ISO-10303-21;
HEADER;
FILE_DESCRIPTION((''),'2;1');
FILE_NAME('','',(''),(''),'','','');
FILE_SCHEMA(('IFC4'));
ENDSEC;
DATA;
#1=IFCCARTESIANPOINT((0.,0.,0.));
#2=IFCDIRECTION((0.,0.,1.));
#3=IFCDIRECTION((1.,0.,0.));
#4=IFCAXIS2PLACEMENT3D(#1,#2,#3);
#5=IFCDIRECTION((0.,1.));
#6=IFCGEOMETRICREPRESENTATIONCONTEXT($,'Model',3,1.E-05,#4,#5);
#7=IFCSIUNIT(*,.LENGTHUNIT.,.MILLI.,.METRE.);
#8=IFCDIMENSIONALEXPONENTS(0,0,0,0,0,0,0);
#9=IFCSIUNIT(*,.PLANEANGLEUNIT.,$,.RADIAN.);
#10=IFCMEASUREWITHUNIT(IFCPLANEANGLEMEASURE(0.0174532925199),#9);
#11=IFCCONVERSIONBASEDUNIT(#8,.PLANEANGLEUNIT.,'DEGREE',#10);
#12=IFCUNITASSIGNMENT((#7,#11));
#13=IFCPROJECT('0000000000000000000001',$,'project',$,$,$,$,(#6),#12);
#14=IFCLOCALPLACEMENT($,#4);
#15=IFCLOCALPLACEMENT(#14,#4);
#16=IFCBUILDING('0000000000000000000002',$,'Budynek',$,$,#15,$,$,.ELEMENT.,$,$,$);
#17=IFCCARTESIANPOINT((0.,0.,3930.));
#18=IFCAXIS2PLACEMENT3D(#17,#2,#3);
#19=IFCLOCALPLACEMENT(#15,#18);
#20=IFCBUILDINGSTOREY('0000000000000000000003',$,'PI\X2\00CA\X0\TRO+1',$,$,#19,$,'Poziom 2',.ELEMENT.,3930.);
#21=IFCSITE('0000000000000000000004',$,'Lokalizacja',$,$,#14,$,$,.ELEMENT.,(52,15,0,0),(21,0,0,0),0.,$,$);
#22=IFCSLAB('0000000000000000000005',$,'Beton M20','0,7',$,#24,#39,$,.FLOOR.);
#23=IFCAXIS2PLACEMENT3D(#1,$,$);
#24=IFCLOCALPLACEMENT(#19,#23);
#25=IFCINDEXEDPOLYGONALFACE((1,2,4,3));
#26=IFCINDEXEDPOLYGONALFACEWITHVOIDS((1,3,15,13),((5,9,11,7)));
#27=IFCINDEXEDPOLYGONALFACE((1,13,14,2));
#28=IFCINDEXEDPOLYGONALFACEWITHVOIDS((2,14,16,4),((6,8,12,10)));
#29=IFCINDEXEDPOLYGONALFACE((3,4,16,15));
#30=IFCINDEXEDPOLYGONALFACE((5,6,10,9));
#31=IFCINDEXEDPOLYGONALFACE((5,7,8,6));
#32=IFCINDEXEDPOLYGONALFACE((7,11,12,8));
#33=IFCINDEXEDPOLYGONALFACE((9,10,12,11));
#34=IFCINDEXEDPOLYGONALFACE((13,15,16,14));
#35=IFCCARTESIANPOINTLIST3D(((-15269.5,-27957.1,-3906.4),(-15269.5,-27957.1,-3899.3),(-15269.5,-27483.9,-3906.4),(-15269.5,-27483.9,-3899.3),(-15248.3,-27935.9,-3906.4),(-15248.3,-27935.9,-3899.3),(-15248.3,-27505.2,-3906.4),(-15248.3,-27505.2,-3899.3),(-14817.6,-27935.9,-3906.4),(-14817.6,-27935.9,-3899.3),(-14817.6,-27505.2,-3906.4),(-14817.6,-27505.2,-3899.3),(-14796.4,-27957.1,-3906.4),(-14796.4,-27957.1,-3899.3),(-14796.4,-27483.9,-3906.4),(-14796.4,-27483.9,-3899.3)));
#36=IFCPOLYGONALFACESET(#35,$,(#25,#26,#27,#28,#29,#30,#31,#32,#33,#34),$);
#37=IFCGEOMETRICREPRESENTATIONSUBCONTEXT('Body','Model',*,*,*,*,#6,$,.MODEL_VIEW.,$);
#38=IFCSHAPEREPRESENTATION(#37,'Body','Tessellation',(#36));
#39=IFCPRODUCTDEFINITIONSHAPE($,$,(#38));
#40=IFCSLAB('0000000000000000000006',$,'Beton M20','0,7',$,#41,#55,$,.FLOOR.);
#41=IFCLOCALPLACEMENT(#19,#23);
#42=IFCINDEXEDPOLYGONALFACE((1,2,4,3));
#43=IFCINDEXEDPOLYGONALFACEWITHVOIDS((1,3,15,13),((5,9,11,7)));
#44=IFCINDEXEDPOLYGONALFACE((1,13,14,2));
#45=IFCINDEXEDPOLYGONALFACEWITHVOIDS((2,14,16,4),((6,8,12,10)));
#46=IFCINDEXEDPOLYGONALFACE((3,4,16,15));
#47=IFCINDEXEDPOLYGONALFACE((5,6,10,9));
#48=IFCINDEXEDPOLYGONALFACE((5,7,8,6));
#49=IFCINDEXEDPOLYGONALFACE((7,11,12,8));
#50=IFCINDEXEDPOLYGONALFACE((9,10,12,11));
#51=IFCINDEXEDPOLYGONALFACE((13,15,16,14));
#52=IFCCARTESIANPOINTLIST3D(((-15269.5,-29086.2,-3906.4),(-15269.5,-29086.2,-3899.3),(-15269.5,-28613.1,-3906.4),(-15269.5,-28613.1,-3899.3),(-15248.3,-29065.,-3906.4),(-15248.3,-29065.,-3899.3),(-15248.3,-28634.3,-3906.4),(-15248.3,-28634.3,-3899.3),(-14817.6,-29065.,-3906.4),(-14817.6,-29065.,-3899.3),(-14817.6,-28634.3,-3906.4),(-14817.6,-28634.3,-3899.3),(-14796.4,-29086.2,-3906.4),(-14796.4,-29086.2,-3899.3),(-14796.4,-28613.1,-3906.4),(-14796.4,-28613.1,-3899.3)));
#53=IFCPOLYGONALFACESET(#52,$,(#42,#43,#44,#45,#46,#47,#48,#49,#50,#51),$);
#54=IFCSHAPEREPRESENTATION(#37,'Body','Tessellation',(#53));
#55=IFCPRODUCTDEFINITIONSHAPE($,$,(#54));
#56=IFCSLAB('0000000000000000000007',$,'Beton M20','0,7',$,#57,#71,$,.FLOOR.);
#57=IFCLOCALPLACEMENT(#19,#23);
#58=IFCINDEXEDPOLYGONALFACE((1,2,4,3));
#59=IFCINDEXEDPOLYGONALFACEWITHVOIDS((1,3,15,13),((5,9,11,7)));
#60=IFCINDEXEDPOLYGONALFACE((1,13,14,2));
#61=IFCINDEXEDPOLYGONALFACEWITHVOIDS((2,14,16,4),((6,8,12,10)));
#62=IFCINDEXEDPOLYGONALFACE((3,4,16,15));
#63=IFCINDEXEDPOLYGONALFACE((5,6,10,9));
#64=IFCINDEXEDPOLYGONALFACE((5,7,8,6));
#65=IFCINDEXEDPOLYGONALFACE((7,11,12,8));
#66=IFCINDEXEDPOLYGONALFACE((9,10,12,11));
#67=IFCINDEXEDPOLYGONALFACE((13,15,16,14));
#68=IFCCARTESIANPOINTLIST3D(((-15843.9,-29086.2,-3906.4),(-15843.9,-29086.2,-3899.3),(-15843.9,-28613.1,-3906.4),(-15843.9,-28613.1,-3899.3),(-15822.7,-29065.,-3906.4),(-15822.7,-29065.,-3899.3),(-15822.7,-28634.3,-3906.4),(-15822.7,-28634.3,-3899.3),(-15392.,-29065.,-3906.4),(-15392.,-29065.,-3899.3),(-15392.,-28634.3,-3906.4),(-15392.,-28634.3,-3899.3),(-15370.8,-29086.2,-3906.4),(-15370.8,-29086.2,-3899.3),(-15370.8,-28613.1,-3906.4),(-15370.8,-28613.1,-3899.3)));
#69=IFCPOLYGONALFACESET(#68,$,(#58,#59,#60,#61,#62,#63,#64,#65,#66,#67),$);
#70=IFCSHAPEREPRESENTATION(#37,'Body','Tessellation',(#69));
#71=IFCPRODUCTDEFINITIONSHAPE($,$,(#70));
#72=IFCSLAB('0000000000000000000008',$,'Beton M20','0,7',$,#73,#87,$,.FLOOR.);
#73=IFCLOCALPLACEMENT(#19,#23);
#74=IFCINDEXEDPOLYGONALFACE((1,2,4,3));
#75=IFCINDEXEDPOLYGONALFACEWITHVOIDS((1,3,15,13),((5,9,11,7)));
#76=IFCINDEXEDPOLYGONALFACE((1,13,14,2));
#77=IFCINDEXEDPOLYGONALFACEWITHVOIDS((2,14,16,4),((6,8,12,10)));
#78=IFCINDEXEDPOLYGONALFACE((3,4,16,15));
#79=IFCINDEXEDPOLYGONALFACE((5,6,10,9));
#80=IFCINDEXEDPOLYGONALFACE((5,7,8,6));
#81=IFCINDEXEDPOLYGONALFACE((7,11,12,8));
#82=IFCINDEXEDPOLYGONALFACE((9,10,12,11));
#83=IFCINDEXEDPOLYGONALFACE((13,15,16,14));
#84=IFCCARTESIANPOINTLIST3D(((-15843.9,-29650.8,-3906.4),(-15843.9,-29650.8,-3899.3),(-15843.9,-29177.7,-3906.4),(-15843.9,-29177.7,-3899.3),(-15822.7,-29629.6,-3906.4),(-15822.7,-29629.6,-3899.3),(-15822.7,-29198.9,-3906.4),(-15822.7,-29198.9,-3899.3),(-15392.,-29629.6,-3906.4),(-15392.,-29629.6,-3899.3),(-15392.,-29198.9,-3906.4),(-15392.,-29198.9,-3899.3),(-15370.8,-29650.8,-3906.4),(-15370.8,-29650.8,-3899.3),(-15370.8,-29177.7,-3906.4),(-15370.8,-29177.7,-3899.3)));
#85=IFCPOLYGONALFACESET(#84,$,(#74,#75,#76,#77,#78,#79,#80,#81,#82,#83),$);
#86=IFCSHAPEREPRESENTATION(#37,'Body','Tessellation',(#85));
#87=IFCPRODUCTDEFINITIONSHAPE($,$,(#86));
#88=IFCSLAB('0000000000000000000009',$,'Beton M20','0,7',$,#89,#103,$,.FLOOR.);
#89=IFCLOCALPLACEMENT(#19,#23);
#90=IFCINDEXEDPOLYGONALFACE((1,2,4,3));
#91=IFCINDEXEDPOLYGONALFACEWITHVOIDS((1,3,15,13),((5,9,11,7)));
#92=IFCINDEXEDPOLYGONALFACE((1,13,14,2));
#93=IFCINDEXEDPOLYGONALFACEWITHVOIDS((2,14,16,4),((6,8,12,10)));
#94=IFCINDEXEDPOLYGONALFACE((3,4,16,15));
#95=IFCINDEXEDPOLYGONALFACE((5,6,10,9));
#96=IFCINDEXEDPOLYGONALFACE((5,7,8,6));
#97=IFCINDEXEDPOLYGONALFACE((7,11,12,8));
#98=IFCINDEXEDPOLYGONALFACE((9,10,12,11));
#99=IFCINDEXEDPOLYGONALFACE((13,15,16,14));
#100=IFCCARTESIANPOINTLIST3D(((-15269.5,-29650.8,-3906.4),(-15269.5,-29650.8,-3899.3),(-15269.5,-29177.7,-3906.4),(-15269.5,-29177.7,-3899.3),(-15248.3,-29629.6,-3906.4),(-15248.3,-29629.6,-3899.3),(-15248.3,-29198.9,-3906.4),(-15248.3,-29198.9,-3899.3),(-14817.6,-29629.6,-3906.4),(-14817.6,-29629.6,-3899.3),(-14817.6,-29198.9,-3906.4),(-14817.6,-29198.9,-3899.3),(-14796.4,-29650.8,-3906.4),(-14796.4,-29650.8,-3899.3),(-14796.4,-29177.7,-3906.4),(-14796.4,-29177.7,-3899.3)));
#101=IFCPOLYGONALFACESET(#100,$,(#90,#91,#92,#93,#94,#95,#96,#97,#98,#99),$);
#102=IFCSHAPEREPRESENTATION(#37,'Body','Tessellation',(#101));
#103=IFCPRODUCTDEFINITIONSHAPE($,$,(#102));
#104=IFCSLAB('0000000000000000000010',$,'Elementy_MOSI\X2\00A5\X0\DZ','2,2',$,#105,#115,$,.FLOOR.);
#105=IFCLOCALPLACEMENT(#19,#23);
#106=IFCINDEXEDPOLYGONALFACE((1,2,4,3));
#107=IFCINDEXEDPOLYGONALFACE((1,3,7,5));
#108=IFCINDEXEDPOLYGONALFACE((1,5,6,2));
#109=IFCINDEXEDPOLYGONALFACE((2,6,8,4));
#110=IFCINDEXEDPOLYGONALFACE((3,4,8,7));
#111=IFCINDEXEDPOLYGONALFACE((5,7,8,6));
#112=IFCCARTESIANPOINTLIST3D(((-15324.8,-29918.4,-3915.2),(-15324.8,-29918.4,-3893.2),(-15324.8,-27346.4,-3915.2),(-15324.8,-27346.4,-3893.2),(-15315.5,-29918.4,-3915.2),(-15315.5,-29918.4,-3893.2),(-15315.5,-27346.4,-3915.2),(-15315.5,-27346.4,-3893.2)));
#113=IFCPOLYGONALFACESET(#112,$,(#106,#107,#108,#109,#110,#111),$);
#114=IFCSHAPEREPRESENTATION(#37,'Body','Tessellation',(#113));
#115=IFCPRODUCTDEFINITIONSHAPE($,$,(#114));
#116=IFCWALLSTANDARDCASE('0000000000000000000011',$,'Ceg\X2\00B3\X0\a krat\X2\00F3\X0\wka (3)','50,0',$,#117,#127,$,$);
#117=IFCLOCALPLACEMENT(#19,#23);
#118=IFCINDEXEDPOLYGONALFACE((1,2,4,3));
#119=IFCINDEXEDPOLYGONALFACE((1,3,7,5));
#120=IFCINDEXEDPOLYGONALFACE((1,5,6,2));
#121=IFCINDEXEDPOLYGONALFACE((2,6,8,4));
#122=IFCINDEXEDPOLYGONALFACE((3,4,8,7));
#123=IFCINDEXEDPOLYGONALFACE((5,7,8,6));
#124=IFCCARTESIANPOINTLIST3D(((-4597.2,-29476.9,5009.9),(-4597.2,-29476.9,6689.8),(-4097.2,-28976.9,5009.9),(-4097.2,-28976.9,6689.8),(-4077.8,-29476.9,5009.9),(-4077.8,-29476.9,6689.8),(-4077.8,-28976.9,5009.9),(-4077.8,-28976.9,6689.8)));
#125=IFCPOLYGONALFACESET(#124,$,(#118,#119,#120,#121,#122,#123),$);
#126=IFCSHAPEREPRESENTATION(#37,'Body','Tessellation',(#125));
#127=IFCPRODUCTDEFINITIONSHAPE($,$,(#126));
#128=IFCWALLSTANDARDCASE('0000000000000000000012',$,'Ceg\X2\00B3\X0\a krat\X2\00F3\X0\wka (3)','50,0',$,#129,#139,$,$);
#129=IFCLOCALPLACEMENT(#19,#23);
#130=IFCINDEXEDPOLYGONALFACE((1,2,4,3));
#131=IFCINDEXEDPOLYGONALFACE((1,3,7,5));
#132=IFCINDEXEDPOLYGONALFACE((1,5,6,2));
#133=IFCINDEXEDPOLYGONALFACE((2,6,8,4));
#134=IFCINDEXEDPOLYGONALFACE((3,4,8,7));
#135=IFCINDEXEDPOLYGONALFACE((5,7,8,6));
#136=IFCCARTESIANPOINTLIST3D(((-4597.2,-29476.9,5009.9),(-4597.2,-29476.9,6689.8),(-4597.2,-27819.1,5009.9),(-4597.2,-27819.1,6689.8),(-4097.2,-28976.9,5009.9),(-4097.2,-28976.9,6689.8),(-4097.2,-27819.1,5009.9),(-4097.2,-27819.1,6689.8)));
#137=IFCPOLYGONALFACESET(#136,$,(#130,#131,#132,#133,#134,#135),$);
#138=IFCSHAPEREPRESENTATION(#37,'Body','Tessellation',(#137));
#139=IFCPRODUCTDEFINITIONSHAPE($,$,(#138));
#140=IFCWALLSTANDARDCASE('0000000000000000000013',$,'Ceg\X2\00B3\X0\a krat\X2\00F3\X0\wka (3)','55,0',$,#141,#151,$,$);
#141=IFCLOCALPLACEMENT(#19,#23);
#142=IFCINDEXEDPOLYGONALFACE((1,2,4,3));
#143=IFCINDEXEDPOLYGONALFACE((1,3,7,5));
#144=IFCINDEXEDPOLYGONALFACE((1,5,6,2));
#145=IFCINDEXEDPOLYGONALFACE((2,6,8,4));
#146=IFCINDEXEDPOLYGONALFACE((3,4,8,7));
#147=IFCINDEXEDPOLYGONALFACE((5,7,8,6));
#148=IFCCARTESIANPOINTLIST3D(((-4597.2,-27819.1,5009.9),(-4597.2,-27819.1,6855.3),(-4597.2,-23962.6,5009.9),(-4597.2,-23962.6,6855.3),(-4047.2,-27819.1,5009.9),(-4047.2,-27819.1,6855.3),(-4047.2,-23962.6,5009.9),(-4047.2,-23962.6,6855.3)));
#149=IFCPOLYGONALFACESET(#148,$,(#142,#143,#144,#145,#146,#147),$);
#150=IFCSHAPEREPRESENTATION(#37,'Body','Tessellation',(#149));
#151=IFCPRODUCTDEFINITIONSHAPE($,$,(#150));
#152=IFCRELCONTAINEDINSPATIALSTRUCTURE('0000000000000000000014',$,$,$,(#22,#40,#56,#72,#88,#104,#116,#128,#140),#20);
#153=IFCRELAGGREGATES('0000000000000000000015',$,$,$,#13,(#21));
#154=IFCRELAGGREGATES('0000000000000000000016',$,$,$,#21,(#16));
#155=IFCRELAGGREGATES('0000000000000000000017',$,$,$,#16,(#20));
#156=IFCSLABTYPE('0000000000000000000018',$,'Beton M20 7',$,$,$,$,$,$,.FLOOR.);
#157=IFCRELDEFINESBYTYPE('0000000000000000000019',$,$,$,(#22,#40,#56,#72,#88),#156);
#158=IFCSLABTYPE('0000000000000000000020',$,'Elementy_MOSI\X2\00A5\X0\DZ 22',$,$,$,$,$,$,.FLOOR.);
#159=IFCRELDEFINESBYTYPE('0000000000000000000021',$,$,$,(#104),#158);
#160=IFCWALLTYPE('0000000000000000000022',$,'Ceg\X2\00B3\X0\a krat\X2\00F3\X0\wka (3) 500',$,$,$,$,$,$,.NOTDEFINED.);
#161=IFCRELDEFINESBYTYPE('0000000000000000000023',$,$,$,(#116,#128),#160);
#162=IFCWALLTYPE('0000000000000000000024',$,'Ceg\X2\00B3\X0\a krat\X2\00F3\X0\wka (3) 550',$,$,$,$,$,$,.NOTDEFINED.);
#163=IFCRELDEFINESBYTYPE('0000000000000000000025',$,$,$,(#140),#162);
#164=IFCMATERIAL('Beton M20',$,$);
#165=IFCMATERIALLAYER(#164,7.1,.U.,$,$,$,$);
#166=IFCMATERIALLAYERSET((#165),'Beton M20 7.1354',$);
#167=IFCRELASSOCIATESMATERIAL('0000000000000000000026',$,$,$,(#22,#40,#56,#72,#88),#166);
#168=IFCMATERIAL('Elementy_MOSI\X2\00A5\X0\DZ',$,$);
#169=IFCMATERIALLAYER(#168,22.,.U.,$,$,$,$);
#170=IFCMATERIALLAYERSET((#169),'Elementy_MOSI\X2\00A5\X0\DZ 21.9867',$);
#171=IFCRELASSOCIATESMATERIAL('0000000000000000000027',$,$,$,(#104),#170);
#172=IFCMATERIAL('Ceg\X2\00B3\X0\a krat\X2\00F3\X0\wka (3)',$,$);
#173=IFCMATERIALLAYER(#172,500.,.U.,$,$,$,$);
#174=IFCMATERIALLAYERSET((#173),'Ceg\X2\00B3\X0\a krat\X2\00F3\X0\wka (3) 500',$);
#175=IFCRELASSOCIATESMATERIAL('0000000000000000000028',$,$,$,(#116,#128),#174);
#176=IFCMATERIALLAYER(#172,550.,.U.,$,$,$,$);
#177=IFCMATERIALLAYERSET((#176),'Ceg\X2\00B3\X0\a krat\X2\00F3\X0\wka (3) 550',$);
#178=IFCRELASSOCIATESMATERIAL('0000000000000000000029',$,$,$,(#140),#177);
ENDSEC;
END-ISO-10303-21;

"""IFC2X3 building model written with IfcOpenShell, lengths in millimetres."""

from ifc_helpers import new_model, entity, si_unit, converted_unit, direction, frame, origin_with_axes, place, context, subcontext, project, spatial, polyline, outline, extrude, material, layer, layer_set, layer_usage, type_object, element, save


model = new_model("IFC2X3")

# Units and contexts
model_context = context("Model", 3, precision=1e-05, world=origin_with_axes(), true_north=direction((0.0, 1.0)))
body_context = subcontext(model_context, "Body", "Model", "MODEL_VIEW")
ifc_project = project(units=[si_unit("LENGTHUNIT", "METRE", prefix="MILLI"), converted_unit("PLANEANGLEUNIT", "DEGREE", entity("IfcPlaneAngleMeasure", 0.0174532925199), si_unit("PLANEANGLEUNIT", "RADIAN"), dimensions=[0, 0, 0, 0, 0, 0, 0])], contexts=[model_context])

# Site, building, storey
site_placement = place(None, origin_with_axes())
site = spatial("IfcSite", under=ifc_project, at=site_placement, Name="Lokalizacja", CompositionType="ELEMENT", RefLatitude=(52, 15, 0, 0), RefLongitude=(21, 0, 0, 0), RefElevation=0.0)
building_placement = place(site_placement, origin_with_axes())
building = spatial("IfcBuilding", under=site, at=building_placement, Name="Budynek", CompositionType="ELEMENT")
storey_placement = place(building_placement, frame((0.0, 0.0, 3930.0), z_axis=(0.0, 0.0, 1.0), x_axis=(1.0, 0.0, 0.0)))
storey = spatial("IfcBuildingStorey", under=building, at=storey_placement, Name="PIÊTRO+1", LongName="Poziom 2", CompositionType="ELEMENT", Elevation=3930.0)

# Shared definitions
ifc_material_1 = material(Name="Beton M20")

# Slabs, openings
ifc_layer_1 = layer(ifc_material_1, 7.1, ventilated="UNKNOWN")
ifc_layer_set_1 = layer_set([ifc_layer_1], Name="Beton M20 7.1354")
slab_type_1 = type_object("IfcSlabType", Name="Beton M20 7", PredefinedType="FLOOR")
ifc_layer_usage_1 = layer_usage(ifc_layer_set_1, "AXIS3", "NEGATIVE", 7.1)
slab_1_placement = place(storey_placement, frame((-15269.5, -27483.9, -3899.3), z_axis=(0.0, 0.0, 1.0), x_axis=(1.0, 0.0, 0.0)))
slab_1 = element("IfcSlab", 1, at=slab_1_placement, inside=storey, type_object=slab_type_1, material=ifc_layer_usage_1, Name="Beton M20", Description="0,7", PredefinedType="FLOOR", context=body_context, shape_type="SweptSolid", body=[
    extrude(outline(polyline([(0.0, 0.0), (0.0, -473.1), (473.1, -473.1), (473.1, 0.0), (0.0, 0.0)])), frame((0.0, 0.0, -7.1), z_axis=(0.0, 0.0, 1.0), x_axis=(1.0, 0.0, 0.0)), (0.0, 0.0, 1.0), 7.1),
])
opening_1_placement = place(slab_1_placement, origin_with_axes())
element("IfcOpeningElement", 2, at=opening_1_placement, cuts=slab_1, context=body_context, shape_type="SweptSolid", body=[
    extrude(outline(polyline([(21.2, -21.2), (21.2, -451.9), (451.9, -451.9), (451.9, -21.2), (21.2, -21.2)])), frame((0.0, 0.0, -7.1), z_axis=(0.0, 0.0, 1.0), x_axis=(1.0, 0.0, 0.0)), (0.0, 0.0, 1.0), 7.1),
])
ifc_layer_usage_2 = layer_usage(ifc_layer_set_1, "AXIS3", "NEGATIVE", 7.1)
slab_2_placement = place(storey_placement, frame((-15269.5, -28613.1, -3899.3), z_axis=(0.0, 0.0, 1.0), x_axis=(1.0, 0.0, 0.0)))
slab_2 = element("IfcSlab", 3, at=slab_2_placement, inside=storey, type_object=slab_type_1, material=ifc_layer_usage_2, Name="Beton M20", Description="0,7", PredefinedType="FLOOR", context=body_context, shape_type="SweptSolid", body=[
    extrude(outline(polyline([(0.0, 0.0), (0.0, -473.1), (473.1, -473.1), (473.1, 0.0), (0.0, 0.0)])), frame((0.0, 0.0, -7.1), z_axis=(0.0, 0.0, 1.0), x_axis=(1.0, 0.0, 0.0)), (0.0, 0.0, 1.0), 7.1),
])
opening_2_placement = place(slab_2_placement, origin_with_axes())
element("IfcOpeningElement", 4, at=opening_2_placement, cuts=slab_2, context=body_context, shape_type="SweptSolid", body=[
    extrude(outline(polyline([(21.2, -21.2), (21.2, -451.9), (451.9, -451.9), (451.9, -21.2), (21.2, -21.2)])), frame((0.0, 0.0, -7.1), z_axis=(0.0, 0.0, 1.0), x_axis=(1.0, 0.0, 0.0)), (0.0, 0.0, 1.0), 7.1),
])
ifc_layer_usage_3 = layer_usage(ifc_layer_set_1, "AXIS3", "NEGATIVE", 7.1)
slab_3_placement = place(storey_placement, frame((-15843.9, -28613.1, -3899.3), z_axis=(0.0, 0.0, 1.0), x_axis=(1.0, 0.0, 0.0)))
slab_3 = element("IfcSlab", 5, at=slab_3_placement, inside=storey, type_object=slab_type_1, material=ifc_layer_usage_3, Name="Beton M20", Description="0,7", PredefinedType="FLOOR", context=body_context, shape_type="SweptSolid", body=[
    extrude(outline(polyline([(0.0, 0.0), (0.0, -473.1), (473.1, -473.1), (473.1, 0.0), (0.0, 0.0)])), frame((0.0, 0.0, -7.1), z_axis=(0.0, 0.0, 1.0), x_axis=(1.0, 0.0, 0.0)), (0.0, 0.0, 1.0), 7.1),
])
opening_3_placement = place(slab_3_placement, origin_with_axes())
element("IfcOpeningElement", 6, at=opening_3_placement, cuts=slab_3, context=body_context, shape_type="SweptSolid", body=[
    extrude(outline(polyline([(21.2, -21.2), (21.2, -451.9), (451.9, -451.9), (451.9, -21.2), (21.2, -21.2)])), frame((0.0, 0.0, -7.1), z_axis=(0.0, 0.0, 1.0), x_axis=(1.0, 0.0, 0.0)), (0.0, 0.0, 1.0), 7.1),
])
ifc_layer_usage_4 = layer_usage(ifc_layer_set_1, "AXIS3", "NEGATIVE", 7.1)
slab_4_placement = place(storey_placement, frame((-15843.9, -29177.7, -3899.3), z_axis=(0.0, 0.0, 1.0), x_axis=(1.0, 0.0, 0.0)))
slab_4 = element("IfcSlab", 7, at=slab_4_placement, inside=storey, type_object=slab_type_1, material=ifc_layer_usage_4, Name="Beton M20", Description="0,7", PredefinedType="FLOOR", context=body_context, shape_type="SweptSolid", body=[
    extrude(outline(polyline([(0.0, 0.0), (0.0, -473.1), (473.1, -473.1), (473.1, 0.0), (0.0, 0.0)])), frame((0.0, 0.0, -7.1), z_axis=(0.0, 0.0, 1.0), x_axis=(1.0, 0.0, 0.0)), (0.0, 0.0, 1.0), 7.1),
])
opening_4_placement = place(slab_4_placement, origin_with_axes())
element("IfcOpeningElement", 8, at=opening_4_placement, cuts=slab_4, context=body_context, shape_type="SweptSolid", body=[
    extrude(outline(polyline([(21.2, -21.2), (21.2, -451.9), (451.9, -451.9), (451.9, -21.2), (21.2, -21.2)])), frame((0.0, 0.0, -7.1), z_axis=(0.0, 0.0, 1.0), x_axis=(1.0, 0.0, 0.0)), (0.0, 0.0, 1.0), 7.1),
])
ifc_layer_usage_5 = layer_usage(ifc_layer_set_1, "AXIS3", "NEGATIVE", 7.1)
slab_5_placement = place(storey_placement, frame((-15269.5, -29177.7, -3899.3), z_axis=(0.0, 0.0, 1.0), x_axis=(1.0, 0.0, 0.0)))
slab_5 = element("IfcSlab", 9, at=slab_5_placement, inside=storey, type_object=slab_type_1, material=ifc_layer_usage_5, Name="Beton M20", Description="0,7", PredefinedType="FLOOR", context=body_context, shape_type="SweptSolid", body=[
    extrude(outline(polyline([(0.0, 0.0), (0.0, -473.1), (473.1, -473.1), (473.1, 0.0), (0.0, 0.0)])), frame((0.0, 0.0, -7.1), z_axis=(0.0, 0.0, 1.0), x_axis=(1.0, 0.0, 0.0)), (0.0, 0.0, 1.0), 7.1),
])
opening_5_placement = place(slab_5_placement, origin_with_axes())
element("IfcOpeningElement", 10, at=opening_5_placement, cuts=slab_5, context=body_context, shape_type="SweptSolid", body=[
    extrude(outline(polyline([(21.2, -21.2), (21.2, -451.9), (451.9, -451.9), (451.9, -21.2), (21.2, -21.2)])), frame((0.0, 0.0, -7.1), z_axis=(0.0, 0.0, 1.0), x_axis=(1.0, 0.0, 0.0)), (0.0, 0.0, 1.0), 7.1),
])

# Slab
ifc_material_2 = material(Name="Elementy_MOSI¥DZ")
ifc_layer_2 = layer(ifc_material_2, 22.0, ventilated="UNKNOWN")
ifc_layer_set_2 = layer_set([ifc_layer_2], Name="Elementy_MOSI¥DZ 21.9867")
ifc_layer_usage_6 = layer_usage(ifc_layer_set_2, "AXIS3", "NEGATIVE", 22.0)
slab_type_2 = type_object("IfcSlabType", Name="Elementy_MOSI¥DZ 22", PredefinedType="FLOOR")
slab_6_placement = place(storey_placement, frame((-15324.8, -29918.4, -3893.2), z_axis=(0.0, 0.0, 1.0), x_axis=(1.0, 0.0, 0.0)))
element("IfcSlab", 11, at=slab_6_placement, inside=storey, type_object=slab_type_2, material=ifc_layer_usage_6, Name="Elementy_MOSI¥DZ", Description="2,2", PredefinedType="FLOOR", context=body_context, shape_type="SweptSolid", body=[
    extrude(outline(polyline([(0.0, 0.0), (9.4, 0.0), (9.4, 2572.0), (0.0, 2572.0), (0.0, 0.0)])), frame((0.0, 0.0, -22.0), z_axis=(0.0, 0.0, 1.0), x_axis=(1.0, 0.0, 0.0)), (0.0, 0.0, 1.0), 22.0),
])

# Walls
ifc_material_3 = material(Name="Ceg³a kratówka (3)")
ifc_layer_3 = layer(ifc_material_3, 500.0, ventilated="UNKNOWN")
ifc_layer_set_3 = layer_set([ifc_layer_3], Name="Ceg³a kratówka (3) 500")
ifc_layer_usage_7 = layer_usage(ifc_layer_set_3, "AXIS2", "NEGATIVE", 0.0)
wall_type_1 = type_object("IfcWallType", Name="Ceg³a kratówka (3) 500", PredefinedType="NOTDEFINED")
wall_1_placement = place(storey_placement, frame((-4597.2, -28976.9, 5009.9), z_axis=(0.0, 0.0, 1.0), x_axis=(1.0, 0.0, 0.0)))
element("IfcWallStandardCase", 12, at=wall_1_placement, inside=storey, type_object=wall_type_1, material=ifc_layer_usage_7, Name="Ceg³a kratówka (3)", Description="50,0", context=body_context, shape_type="SweptSolid", body=[
    extrude(outline(polyline([(0.0, -500.0), (519.4, -500.0), (519.4, 0.0), (500.0, 0.0), (0.0, -500.0)])), origin_with_axes(), (0.0, 0.0, 1.0), 1679.9),
])
ifc_layer_usage_8 = layer_usage(ifc_layer_set_3, "AXIS2", "NEGATIVE", 0.0)
wall_2_placement = place(storey_placement, frame((-4597.2, -28976.9, 5009.9), z_axis=(0.0, 0.0, 1.0), x_axis=(0.0, 1.0, 0.0)))
element("IfcWallStandardCase", 13, at=wall_2_placement, inside=storey, type_object=wall_type_1, material=ifc_layer_usage_8, Name="Ceg³a kratówka (3)", Description="50,0", context=body_context, shape_type="SweptSolid", body=[
    extrude(outline(polyline([(0.0, -500.0), (1157.9, -500.0), (1157.9, 0.0), (-500.0, 0.0), (0.0, -500.0)])), origin_with_axes(), (0.0, 0.0, 1.0), 1679.9),
])
ifc_layer_4 = layer(ifc_material_3, 550.0, ventilated="UNKNOWN")
ifc_layer_set_4 = layer_set([ifc_layer_4], Name="Ceg³a kratówka (3) 550")
ifc_layer_usage_9 = layer_usage(ifc_layer_set_4, "AXIS2", "NEGATIVE", 0.0)
wall_type_2 = type_object("IfcWallType", Name="Ceg³a kratówka (3) 550", PredefinedType="NOTDEFINED")
wall_3_placement = place(storey_placement, frame((-4597.2, -27819.1, 5009.9), z_axis=(0.0, 0.0, 1.0), x_axis=(0.0, 1.0, 0.0)))
element("IfcWallStandardCase", 14, at=wall_3_placement, inside=storey, type_object=wall_type_2, material=ifc_layer_usage_9, Name="Ceg³a kratówka (3)", Description="55,0", context=body_context, shape_type="SweptSolid", body=[
    extrude(outline(polyline([(0.0, -550.0), (3856.5, -550.0), (3856.5, 0.0), (0.0, 0.0), (0.0, -550.0)])), origin_with_axes(), (0.0, 0.0, 1.0), 1845.4),
])

save(model, "model.ifc")
